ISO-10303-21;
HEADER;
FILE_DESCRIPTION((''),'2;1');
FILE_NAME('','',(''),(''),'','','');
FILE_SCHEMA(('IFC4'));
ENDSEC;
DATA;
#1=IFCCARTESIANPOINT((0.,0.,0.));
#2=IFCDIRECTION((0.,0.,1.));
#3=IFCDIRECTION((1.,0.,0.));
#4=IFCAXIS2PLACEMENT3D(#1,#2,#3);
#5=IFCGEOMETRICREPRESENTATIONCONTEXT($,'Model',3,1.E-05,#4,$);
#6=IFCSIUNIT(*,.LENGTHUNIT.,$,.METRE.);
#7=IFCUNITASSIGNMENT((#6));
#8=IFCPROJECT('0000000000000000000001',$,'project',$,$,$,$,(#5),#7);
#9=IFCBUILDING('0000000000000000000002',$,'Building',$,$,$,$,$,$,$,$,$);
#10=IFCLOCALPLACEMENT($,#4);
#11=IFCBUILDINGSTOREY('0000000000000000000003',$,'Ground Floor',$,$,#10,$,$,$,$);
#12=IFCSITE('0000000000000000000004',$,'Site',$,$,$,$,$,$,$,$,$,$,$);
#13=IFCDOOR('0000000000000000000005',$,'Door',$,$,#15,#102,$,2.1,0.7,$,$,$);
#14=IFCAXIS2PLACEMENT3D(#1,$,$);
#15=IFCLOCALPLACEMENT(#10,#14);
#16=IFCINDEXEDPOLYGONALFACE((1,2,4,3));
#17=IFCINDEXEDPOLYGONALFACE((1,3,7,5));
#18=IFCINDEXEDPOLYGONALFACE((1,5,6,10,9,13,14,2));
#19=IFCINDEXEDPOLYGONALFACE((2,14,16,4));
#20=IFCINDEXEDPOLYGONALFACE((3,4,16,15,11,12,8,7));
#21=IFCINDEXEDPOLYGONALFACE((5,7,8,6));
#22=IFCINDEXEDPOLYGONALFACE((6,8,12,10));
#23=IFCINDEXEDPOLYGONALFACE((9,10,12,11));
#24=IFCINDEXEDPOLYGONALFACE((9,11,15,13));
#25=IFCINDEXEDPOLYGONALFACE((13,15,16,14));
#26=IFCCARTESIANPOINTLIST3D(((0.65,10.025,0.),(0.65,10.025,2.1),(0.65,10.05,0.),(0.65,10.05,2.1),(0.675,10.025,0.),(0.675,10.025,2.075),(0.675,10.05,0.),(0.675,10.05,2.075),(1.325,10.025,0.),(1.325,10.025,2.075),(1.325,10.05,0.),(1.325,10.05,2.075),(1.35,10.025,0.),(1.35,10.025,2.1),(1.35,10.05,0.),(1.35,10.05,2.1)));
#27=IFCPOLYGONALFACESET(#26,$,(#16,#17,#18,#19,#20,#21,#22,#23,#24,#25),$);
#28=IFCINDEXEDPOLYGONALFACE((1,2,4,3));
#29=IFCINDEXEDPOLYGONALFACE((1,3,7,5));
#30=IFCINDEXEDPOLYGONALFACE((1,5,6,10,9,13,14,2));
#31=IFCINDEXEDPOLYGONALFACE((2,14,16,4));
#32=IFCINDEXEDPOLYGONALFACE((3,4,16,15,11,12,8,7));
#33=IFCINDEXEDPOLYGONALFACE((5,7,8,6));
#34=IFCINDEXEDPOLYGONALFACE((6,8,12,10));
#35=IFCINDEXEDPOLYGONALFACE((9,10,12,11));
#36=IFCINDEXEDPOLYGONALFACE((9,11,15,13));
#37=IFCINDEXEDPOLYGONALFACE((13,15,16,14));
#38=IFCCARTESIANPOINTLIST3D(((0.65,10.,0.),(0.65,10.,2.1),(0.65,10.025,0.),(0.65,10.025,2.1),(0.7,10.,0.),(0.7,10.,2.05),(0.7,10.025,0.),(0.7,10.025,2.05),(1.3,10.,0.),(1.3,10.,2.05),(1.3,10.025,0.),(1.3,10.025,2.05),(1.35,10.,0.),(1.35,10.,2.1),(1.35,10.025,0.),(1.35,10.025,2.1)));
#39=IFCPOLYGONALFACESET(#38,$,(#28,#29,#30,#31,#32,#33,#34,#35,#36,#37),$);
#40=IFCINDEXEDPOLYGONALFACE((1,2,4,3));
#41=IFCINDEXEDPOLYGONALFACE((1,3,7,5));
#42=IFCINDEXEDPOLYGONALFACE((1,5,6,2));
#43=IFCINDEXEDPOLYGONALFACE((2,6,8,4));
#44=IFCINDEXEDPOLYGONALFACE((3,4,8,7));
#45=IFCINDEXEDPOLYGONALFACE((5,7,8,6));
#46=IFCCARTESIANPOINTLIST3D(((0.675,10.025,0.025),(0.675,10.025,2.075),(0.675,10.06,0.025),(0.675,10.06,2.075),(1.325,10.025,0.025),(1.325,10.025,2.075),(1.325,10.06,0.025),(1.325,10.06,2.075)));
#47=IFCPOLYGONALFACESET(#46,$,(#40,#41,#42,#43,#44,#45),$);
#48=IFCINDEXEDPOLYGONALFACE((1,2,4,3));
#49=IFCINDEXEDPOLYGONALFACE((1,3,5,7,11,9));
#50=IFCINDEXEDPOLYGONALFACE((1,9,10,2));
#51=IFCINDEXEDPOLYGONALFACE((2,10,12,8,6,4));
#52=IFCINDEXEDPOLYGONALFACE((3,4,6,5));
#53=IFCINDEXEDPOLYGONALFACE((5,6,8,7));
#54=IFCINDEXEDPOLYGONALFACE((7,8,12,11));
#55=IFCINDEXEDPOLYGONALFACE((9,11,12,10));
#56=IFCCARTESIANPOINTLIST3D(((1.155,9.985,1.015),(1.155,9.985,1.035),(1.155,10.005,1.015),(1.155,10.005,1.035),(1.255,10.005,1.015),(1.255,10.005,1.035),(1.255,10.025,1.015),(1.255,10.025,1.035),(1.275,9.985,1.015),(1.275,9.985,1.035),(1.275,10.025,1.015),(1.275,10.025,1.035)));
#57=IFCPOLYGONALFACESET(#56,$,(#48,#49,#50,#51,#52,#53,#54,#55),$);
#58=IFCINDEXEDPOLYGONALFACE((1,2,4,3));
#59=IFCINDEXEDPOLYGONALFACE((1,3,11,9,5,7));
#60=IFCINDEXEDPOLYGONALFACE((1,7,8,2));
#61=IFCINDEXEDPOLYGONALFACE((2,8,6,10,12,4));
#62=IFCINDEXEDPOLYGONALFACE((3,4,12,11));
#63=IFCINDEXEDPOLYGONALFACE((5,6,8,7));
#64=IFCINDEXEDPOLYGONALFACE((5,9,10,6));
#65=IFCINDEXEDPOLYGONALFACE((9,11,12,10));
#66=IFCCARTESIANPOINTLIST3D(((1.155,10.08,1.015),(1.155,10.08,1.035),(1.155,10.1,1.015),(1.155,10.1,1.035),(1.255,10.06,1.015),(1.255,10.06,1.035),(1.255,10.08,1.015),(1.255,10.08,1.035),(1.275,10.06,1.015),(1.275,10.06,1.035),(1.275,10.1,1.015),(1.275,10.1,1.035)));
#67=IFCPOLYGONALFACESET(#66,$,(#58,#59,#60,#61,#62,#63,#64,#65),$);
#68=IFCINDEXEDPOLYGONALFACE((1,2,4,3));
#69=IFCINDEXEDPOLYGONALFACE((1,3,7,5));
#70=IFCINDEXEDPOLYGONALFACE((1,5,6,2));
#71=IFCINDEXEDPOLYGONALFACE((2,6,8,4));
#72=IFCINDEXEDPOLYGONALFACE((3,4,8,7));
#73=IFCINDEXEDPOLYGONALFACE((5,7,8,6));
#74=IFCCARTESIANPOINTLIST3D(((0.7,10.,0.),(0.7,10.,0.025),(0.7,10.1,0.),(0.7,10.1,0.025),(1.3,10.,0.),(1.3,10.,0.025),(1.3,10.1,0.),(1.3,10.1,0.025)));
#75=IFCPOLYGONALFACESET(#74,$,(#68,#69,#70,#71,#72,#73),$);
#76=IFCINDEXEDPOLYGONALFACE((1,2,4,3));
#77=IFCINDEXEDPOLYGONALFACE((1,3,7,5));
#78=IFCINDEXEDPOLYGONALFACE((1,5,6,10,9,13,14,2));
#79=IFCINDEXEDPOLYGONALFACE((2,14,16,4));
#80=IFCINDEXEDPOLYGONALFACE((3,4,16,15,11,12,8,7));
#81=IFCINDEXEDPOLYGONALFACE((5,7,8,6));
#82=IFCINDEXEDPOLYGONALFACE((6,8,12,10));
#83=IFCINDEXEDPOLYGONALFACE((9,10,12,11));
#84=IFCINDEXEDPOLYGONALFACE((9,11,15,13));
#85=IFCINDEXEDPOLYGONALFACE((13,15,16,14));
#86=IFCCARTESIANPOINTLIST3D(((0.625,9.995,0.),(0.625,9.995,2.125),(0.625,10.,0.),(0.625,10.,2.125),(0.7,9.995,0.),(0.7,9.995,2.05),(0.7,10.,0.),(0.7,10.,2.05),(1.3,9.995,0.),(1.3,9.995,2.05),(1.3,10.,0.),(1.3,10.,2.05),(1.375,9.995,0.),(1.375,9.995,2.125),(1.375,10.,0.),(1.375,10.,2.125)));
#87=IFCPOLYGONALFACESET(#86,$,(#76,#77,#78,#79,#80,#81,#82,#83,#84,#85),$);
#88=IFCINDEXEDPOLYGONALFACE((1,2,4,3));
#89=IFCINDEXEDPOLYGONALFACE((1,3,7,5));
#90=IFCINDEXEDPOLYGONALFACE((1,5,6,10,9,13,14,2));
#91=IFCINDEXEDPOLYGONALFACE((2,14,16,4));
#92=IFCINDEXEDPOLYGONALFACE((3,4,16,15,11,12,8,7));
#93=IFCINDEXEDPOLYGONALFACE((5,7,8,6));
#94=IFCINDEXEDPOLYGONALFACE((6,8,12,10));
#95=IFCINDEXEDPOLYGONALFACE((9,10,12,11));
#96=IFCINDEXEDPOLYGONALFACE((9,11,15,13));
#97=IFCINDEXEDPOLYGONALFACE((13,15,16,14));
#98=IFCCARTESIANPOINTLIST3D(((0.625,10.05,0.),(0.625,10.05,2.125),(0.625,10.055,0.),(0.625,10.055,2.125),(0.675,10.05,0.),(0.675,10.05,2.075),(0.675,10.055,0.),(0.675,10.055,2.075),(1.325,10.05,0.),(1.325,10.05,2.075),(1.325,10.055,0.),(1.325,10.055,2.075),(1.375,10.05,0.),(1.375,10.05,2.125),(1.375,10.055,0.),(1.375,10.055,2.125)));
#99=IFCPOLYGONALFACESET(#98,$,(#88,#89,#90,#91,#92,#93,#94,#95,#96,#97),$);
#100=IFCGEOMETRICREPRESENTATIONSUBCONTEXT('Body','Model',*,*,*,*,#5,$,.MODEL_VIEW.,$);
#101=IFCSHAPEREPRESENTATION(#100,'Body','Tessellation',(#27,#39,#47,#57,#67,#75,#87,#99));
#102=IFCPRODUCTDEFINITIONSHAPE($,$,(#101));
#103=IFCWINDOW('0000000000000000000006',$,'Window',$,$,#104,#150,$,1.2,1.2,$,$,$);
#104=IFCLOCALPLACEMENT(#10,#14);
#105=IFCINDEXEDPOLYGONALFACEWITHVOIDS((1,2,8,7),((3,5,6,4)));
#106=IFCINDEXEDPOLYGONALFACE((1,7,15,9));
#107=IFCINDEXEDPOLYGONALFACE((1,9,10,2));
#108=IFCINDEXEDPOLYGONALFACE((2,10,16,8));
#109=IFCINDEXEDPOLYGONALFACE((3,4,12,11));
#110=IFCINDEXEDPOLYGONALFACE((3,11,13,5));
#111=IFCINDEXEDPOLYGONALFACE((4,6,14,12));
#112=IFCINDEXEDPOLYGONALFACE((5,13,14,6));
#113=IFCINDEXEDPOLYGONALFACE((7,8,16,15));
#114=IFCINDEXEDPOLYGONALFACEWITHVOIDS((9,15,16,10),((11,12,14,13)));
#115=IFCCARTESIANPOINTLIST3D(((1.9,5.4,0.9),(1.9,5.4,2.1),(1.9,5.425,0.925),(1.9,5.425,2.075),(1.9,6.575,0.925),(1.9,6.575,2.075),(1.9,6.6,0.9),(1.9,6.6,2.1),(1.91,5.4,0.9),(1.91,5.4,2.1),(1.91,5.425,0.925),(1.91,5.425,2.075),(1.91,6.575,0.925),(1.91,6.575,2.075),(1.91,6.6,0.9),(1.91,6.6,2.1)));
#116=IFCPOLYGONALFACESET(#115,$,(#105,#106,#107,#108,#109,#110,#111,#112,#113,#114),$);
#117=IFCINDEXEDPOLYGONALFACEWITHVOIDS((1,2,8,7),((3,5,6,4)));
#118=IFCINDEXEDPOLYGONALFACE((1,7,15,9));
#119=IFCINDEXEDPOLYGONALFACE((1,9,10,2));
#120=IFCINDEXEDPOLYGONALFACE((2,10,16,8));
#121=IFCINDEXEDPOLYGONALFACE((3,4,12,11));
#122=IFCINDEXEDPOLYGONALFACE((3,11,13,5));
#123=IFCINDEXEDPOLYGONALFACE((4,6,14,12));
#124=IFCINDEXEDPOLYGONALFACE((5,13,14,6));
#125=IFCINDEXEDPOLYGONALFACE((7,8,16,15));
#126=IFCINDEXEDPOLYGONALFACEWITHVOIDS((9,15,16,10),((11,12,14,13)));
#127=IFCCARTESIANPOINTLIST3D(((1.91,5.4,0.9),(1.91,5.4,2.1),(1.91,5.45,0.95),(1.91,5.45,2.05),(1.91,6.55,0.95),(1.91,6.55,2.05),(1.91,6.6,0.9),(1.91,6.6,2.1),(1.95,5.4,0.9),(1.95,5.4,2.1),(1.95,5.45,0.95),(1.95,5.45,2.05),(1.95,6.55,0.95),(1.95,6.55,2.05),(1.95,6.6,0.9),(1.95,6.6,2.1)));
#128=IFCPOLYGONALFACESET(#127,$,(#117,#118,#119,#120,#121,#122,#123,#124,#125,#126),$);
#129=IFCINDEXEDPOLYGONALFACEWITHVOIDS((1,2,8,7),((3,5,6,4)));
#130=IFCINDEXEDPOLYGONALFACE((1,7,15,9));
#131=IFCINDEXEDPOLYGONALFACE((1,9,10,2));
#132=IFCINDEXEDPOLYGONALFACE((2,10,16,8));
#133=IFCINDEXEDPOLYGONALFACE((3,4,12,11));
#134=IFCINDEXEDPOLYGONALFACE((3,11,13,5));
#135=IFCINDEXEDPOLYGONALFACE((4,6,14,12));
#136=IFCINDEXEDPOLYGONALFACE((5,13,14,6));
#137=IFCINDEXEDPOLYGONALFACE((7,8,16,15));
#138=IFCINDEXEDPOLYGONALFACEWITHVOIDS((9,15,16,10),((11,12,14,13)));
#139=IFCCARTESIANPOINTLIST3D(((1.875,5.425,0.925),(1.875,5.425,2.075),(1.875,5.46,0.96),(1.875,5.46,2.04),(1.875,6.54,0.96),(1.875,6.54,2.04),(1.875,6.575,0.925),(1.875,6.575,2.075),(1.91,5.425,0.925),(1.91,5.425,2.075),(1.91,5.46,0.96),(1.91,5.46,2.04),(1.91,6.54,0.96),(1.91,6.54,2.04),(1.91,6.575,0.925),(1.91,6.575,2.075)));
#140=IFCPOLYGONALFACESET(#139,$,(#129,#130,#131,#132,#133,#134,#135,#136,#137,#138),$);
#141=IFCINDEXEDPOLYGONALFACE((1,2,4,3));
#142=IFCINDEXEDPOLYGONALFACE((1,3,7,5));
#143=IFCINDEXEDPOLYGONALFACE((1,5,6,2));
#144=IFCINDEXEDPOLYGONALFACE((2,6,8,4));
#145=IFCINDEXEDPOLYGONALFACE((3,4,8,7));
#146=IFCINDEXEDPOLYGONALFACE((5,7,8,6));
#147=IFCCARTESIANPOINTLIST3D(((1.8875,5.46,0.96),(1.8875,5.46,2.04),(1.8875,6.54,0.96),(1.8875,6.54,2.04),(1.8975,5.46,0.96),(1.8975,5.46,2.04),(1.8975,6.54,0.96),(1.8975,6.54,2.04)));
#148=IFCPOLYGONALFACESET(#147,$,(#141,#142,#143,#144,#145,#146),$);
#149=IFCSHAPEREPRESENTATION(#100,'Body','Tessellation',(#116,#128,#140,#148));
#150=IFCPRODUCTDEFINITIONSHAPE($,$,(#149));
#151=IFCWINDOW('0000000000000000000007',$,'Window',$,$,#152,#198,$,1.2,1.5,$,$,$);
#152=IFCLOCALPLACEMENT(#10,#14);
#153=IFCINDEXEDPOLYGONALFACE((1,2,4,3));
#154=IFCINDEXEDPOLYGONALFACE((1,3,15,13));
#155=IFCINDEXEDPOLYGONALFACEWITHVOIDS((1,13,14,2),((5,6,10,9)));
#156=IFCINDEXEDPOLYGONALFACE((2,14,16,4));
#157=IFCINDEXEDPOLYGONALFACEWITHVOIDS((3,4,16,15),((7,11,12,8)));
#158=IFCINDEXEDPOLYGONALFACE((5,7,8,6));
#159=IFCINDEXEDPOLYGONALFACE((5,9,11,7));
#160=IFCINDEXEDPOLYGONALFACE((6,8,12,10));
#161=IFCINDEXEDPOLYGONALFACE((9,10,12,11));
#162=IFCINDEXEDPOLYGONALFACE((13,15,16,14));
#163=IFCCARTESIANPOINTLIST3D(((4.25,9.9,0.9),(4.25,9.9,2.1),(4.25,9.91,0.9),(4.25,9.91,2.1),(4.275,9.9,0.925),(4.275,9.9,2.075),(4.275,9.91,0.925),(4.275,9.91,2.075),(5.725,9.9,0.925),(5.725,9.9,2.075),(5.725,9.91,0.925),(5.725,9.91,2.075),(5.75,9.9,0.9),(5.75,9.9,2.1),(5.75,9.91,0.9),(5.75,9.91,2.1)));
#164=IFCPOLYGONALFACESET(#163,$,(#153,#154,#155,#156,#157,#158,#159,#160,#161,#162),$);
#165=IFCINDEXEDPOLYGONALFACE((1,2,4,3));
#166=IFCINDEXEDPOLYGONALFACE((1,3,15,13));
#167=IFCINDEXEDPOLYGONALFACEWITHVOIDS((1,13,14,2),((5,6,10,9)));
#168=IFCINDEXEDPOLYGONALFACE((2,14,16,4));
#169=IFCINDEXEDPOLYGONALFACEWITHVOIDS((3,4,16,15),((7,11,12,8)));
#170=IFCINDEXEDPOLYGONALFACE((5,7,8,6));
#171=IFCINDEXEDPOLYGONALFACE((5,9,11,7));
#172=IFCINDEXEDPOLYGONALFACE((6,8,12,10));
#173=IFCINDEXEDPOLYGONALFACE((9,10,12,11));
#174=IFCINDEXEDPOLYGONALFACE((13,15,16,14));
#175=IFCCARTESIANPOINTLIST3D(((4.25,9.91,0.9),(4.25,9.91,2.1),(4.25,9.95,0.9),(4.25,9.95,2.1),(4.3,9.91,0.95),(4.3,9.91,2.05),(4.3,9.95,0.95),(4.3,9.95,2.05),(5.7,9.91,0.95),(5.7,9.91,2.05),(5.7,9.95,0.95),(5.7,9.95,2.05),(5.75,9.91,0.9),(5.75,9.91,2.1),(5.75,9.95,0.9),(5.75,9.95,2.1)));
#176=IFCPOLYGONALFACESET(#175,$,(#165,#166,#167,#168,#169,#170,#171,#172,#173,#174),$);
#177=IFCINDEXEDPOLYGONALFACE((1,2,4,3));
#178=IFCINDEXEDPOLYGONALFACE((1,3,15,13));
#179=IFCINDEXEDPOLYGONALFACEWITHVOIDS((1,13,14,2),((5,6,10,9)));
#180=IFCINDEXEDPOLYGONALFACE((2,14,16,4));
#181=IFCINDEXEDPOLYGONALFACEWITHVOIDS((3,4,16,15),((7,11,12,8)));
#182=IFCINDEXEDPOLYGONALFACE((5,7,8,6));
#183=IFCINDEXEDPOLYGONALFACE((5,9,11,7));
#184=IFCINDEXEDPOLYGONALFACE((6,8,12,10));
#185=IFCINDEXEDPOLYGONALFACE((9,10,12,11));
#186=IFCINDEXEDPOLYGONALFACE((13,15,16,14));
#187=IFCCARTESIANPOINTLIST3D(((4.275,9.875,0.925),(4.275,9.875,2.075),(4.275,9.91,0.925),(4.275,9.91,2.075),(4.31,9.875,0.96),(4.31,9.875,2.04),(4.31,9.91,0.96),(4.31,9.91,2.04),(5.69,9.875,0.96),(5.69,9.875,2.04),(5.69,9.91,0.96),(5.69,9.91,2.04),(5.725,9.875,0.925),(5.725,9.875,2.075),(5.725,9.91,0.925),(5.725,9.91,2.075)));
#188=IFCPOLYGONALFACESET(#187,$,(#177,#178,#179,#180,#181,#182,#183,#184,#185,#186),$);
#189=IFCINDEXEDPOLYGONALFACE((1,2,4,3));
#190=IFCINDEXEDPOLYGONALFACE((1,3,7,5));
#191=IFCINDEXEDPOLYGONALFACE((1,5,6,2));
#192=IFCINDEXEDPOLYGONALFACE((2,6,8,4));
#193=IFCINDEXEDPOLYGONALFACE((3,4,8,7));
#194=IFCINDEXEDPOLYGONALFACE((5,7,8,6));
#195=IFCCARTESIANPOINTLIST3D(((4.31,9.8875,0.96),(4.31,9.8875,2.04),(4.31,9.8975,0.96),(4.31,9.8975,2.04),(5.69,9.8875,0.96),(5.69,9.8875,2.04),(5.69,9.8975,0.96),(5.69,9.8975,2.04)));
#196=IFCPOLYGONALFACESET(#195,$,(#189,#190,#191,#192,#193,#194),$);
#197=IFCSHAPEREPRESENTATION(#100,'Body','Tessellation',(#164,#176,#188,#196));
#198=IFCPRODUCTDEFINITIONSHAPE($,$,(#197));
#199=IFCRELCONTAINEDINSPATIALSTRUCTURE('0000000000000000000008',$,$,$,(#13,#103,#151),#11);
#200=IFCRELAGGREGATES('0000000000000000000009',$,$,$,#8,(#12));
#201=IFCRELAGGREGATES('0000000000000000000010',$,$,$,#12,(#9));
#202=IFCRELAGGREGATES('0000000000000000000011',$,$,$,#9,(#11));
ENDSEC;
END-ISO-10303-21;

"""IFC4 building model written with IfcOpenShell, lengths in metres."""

from ifc_helpers import new_model, si_unit, frame, origin_with_axes, place, context, subcontext, project, spatial, line, indexed_curve, outline, extrude, element, save


model = new_model("IFC4")

# Units and contexts
model_context = context("Model", 3, precision=1e-05, world=origin_with_axes())
body_context = subcontext(model_context, "Body", "Model", "MODEL_VIEW")
ifc_project = project(units=[si_unit("LENGTHUNIT", "METRE")], contexts=[model_context])

# Site, building, storey
site = spatial("IfcSite", under=ifc_project, Name="Site")
building = spatial("IfcBuilding", under=site, Name="Building")
storey_placement = place(None, origin_with_axes())
storey = spatial("IfcBuildingStorey", under=building, at=storey_placement, Name="Ground Floor")

# Door
door_1_placement = place(storey_placement, frame((0.65, 10.0, 0.0), z_axis=(0.0, 0.0, 1.0), x_axis=(1.0, 0.0, 0.0)))
element("IfcDoor", 1, at=door_1_placement, inside=storey, Name="Door", OverallHeight=2.1, OverallWidth=0.7, context=body_context, shape_type="SweptSolid", body=[
    extrude(outline(indexed_curve([(0.0, 0.0), (0.0, 2.1), (0.7, 2.1), (0.7, 0.0), (0.675, 0.0), (0.675, 2.075), (0.025, 2.075), (0.025, 0.0)], segments=[line(1, 2, 3, 4, 5, 6, 7, 8, 1)])), frame((0.0, 0.025, 0.0), z_axis=(0.0, -1.0, 0.0), x_axis=(1.0, 0.0, 0.0)), (0.0, 0.0, -1.0), 0.025),
    extrude(outline(indexed_curve([(0.0, 0.0), (0.0, 2.1), (0.7, 2.1), (0.7, 0.0), (0.65, 0.0), (0.65, 2.05), (0.05, 2.05), (0.05, 0.0)], segments=[line(1, 2, 3, 4, 5, 6, 7, 8, 1)])), frame((0.0, 0.0, 0.0), z_axis=(0.0, -1.0, 0.0), x_axis=(1.0, 0.0, 0.0)), (0.0, 0.0, -1.0), 0.025),
    extrude(outline(indexed_curve([(0.0, 0.0), (0.65, 0.0), (0.65, 0.035), (0.0, 0.035)], segments=[line(1, 2, 3, 4, 1)])), frame((0.025, 0.025, 0.025), z_axis=(0.0, 0.0, 1.0), x_axis=(1.0, 0.0, 0.0)), (0.0, 0.0, 1.0), 2.05),
    extrude(outline(indexed_curve([(0.0, 0.0), (0.0, -0.04), (-0.12, -0.04), (-0.12, -0.02), (-0.02, -0.02), (-0.02, 0.0)], segments=[line(1, 2, 3, 4, 5, 6, 1)])), frame((0.625, 0.025, 1.015), z_axis=(0.0, 0.0, 1.0), x_axis=(1.0, 0.0, 0.0)), (0.0, 0.0, 1.0), 0.02),
    extrude(outline(indexed_curve([(0.0, 0.0), (0.0, 0.04), (-0.12, 0.04), (-0.12, 0.02), (-0.02, 0.02), (-0.02, 0.0)], segments=[line(1, 2, 3, 4, 5, 6, 1)])), frame((0.625, 0.06, 1.015), z_axis=(0.0, 0.0, 1.0), x_axis=(1.0, 0.0, 0.0)), (0.0, 0.0, 1.0), 0.02),
    extrude(outline(indexed_curve([(0.0, 0.0), (0.6, 0.0), (0.6, 0.1), (0.0, 0.1)], segments=[line(1, 2, 3, 4, 1)])), frame((0.05, 0.0, 0.0), z_axis=(0.0, 0.0, 1.0), x_axis=(1.0, 0.0, 0.0)), (0.0, 0.0, 1.0), 0.025),
    extrude(outline(indexed_curve([(0.0, 0.0), (0.0, 2.125), (0.75, 2.125), (0.75, 0.0), (0.675, 0.0), (0.675, 2.05), (0.075, 2.05), (0.075, 0.0)], segments=[line(1, 2, 3, 4, 5, 6, 7, 8, 1)])), frame((-0.025, -0.005, 0.0), z_axis=(0.0, -1.0, 0.0), x_axis=(1.0, 0.0, 0.0)), (0.0, 0.0, -1.0), 0.005),
    extrude(outline(indexed_curve([(0.0, 0.0), (0.0, 2.125), (0.75, 2.125), (0.75, 0.0), (0.7, 0.0), (0.7, 2.075), (0.05, 2.075), (0.05, 0.0)], segments=[line(1, 2, 3, 4, 5, 6, 7, 8, 1)])), frame((-0.025, 0.05, 0.0), z_axis=(0.0, -1.0, 0.0), x_axis=(1.0, 0.0, 0.0)), (0.0, 0.0, -1.0), 0.005),
])

# Windows
window_1_placement = place(storey_placement, frame((2.0, 5.4, 0.9), z_axis=(0.0, 0.0, 1.0), x_axis=(0.0, 1.0, 0.0)))
element("IfcWindow", 2, at=window_1_placement, inside=storey, Name="Window", OverallHeight=1.2, OverallWidth=1.2, context=body_context, shape_type="SweptSolid", body=[
    extrude(outline(indexed_curve([(0.0, 0.0), (1.2, 0.0), (1.2, 1.2), (0.0, 1.2)], segments=[line(1, 2, 3, 4, 1)]), holes=[indexed_curve([(0.025, 0.025), (1.175, 0.025), (1.175, 1.175), (0.025, 1.175)], segments=[line(1, 2, 3, 4, 1)])]), frame((0.0, 0.09, 0.0), z_axis=(0.0, -1.0, 0.0), x_axis=(1.0, 0.0, 0.0)), (0.0, 0.0, -1.0), 0.01),
    extrude(outline(indexed_curve([(0.0, 0.0), (1.2, 0.0), (1.2, 1.2), (0.0, 1.2)], segments=[line(1, 2, 3, 4, 1)]), holes=[indexed_curve([(0.05, 0.05), (1.15, 0.05), (1.15, 1.15), (0.05, 1.15)], segments=[line(1, 2, 3, 4, 1)])]), frame((0.0, 0.05, 0.0), z_axis=(0.0, -1.0, 0.0), x_axis=(1.0, 0.0, 0.0)), (0.0, 0.0, -1.0), 0.04),
    extrude(outline(indexed_curve([(0.0, 0.0), (1.15, 0.0), (1.15, 1.15), (0.0, 1.15)], segments=[line(1, 2, 3, 4, 1)]), holes=[indexed_curve([(0.035, 0.035), (1.115, 0.035), (1.115, 1.115), (0.035, 1.115)], segments=[line(1, 2, 3, 4, 1)])]), frame((0.025, 0.09, 0.025), z_axis=(0.0, -1.0, 0.0), x_axis=(1.0, 0.0, 0.0)), (0.0, 0.0, -1.0), 0.035),
    extrude(outline(indexed_curve([(0.035, 0.035), (1.115, 0.035), (1.115, 1.115), (0.035, 1.115)], segments=[line(1, 2, 3, 4, 1)])), frame((0.025, 0.1025, 0.025), z_axis=(0.0, -1.0, 0.0), x_axis=(1.0, 0.0, 0.0)), (0.0, 0.0, -1.0), 0.01),
])
window_2_placement = place(storey_placement, frame((5.75, 10.0, 0.9), z_axis=(0.0, 0.0, 1.0), x_axis=(-1.0, 0.0, 0.0)))
element("IfcWindow", 3, at=window_2_placement, inside=storey, Name="Window", OverallHeight=1.2, OverallWidth=1.5, context=body_context, shape_type="SweptSolid", body=[
    extrude(outline(indexed_curve([(0.0, 0.0), (1.5, 0.0), (1.5, 1.2), (0.0, 1.2)], segments=[line(1, 2, 3, 4, 1)]), holes=[indexed_curve([(0.025, 0.025), (1.475, 0.025), (1.475, 1.175), (0.025, 1.175)], segments=[line(1, 2, 3, 4, 1)])]), frame((0.0, 0.09, 0.0), z_axis=(0.0, -1.0, 0.0), x_axis=(1.0, 0.0, 0.0)), (0.0, 0.0, -1.0), 0.01),
    extrude(outline(indexed_curve([(0.0, 0.0), (1.5, 0.0), (1.5, 1.2), (0.0, 1.2)], segments=[line(1, 2, 3, 4, 1)]), holes=[indexed_curve([(0.05, 0.05), (1.45, 0.05), (1.45, 1.15), (0.05, 1.15)], segments=[line(1, 2, 3, 4, 1)])]), frame((0.0, 0.05, 0.0), z_axis=(0.0, -1.0, 0.0), x_axis=(1.0, 0.0, 0.0)), (0.0, 0.0, -1.0), 0.04),
    extrude(outline(indexed_curve([(0.0, 0.0), (1.45, 0.0), (1.45, 1.15), (0.0, 1.15)], segments=[line(1, 2, 3, 4, 1)]), holes=[indexed_curve([(0.035, 0.035), (1.415, 0.035), (1.415, 1.115), (0.035, 1.115)], segments=[line(1, 2, 3, 4, 1)])]), frame((0.025, 0.09, 0.025), z_axis=(0.0, -1.0, 0.0), x_axis=(1.0, 0.0, 0.0)), (0.0, 0.0, -1.0), 0.035),
    extrude(outline(indexed_curve([(0.035, 0.035), (1.415, 0.035), (1.415, 1.115), (0.035, 1.115)], segments=[line(1, 2, 3, 4, 1)])), frame((0.025, 0.1025, 0.025), z_axis=(0.0, -1.0, 0.0), x_axis=(1.0, 0.0, 0.0)), (0.0, 0.0, -1.0), 0.01),
])

save(model, "model.ifc")
